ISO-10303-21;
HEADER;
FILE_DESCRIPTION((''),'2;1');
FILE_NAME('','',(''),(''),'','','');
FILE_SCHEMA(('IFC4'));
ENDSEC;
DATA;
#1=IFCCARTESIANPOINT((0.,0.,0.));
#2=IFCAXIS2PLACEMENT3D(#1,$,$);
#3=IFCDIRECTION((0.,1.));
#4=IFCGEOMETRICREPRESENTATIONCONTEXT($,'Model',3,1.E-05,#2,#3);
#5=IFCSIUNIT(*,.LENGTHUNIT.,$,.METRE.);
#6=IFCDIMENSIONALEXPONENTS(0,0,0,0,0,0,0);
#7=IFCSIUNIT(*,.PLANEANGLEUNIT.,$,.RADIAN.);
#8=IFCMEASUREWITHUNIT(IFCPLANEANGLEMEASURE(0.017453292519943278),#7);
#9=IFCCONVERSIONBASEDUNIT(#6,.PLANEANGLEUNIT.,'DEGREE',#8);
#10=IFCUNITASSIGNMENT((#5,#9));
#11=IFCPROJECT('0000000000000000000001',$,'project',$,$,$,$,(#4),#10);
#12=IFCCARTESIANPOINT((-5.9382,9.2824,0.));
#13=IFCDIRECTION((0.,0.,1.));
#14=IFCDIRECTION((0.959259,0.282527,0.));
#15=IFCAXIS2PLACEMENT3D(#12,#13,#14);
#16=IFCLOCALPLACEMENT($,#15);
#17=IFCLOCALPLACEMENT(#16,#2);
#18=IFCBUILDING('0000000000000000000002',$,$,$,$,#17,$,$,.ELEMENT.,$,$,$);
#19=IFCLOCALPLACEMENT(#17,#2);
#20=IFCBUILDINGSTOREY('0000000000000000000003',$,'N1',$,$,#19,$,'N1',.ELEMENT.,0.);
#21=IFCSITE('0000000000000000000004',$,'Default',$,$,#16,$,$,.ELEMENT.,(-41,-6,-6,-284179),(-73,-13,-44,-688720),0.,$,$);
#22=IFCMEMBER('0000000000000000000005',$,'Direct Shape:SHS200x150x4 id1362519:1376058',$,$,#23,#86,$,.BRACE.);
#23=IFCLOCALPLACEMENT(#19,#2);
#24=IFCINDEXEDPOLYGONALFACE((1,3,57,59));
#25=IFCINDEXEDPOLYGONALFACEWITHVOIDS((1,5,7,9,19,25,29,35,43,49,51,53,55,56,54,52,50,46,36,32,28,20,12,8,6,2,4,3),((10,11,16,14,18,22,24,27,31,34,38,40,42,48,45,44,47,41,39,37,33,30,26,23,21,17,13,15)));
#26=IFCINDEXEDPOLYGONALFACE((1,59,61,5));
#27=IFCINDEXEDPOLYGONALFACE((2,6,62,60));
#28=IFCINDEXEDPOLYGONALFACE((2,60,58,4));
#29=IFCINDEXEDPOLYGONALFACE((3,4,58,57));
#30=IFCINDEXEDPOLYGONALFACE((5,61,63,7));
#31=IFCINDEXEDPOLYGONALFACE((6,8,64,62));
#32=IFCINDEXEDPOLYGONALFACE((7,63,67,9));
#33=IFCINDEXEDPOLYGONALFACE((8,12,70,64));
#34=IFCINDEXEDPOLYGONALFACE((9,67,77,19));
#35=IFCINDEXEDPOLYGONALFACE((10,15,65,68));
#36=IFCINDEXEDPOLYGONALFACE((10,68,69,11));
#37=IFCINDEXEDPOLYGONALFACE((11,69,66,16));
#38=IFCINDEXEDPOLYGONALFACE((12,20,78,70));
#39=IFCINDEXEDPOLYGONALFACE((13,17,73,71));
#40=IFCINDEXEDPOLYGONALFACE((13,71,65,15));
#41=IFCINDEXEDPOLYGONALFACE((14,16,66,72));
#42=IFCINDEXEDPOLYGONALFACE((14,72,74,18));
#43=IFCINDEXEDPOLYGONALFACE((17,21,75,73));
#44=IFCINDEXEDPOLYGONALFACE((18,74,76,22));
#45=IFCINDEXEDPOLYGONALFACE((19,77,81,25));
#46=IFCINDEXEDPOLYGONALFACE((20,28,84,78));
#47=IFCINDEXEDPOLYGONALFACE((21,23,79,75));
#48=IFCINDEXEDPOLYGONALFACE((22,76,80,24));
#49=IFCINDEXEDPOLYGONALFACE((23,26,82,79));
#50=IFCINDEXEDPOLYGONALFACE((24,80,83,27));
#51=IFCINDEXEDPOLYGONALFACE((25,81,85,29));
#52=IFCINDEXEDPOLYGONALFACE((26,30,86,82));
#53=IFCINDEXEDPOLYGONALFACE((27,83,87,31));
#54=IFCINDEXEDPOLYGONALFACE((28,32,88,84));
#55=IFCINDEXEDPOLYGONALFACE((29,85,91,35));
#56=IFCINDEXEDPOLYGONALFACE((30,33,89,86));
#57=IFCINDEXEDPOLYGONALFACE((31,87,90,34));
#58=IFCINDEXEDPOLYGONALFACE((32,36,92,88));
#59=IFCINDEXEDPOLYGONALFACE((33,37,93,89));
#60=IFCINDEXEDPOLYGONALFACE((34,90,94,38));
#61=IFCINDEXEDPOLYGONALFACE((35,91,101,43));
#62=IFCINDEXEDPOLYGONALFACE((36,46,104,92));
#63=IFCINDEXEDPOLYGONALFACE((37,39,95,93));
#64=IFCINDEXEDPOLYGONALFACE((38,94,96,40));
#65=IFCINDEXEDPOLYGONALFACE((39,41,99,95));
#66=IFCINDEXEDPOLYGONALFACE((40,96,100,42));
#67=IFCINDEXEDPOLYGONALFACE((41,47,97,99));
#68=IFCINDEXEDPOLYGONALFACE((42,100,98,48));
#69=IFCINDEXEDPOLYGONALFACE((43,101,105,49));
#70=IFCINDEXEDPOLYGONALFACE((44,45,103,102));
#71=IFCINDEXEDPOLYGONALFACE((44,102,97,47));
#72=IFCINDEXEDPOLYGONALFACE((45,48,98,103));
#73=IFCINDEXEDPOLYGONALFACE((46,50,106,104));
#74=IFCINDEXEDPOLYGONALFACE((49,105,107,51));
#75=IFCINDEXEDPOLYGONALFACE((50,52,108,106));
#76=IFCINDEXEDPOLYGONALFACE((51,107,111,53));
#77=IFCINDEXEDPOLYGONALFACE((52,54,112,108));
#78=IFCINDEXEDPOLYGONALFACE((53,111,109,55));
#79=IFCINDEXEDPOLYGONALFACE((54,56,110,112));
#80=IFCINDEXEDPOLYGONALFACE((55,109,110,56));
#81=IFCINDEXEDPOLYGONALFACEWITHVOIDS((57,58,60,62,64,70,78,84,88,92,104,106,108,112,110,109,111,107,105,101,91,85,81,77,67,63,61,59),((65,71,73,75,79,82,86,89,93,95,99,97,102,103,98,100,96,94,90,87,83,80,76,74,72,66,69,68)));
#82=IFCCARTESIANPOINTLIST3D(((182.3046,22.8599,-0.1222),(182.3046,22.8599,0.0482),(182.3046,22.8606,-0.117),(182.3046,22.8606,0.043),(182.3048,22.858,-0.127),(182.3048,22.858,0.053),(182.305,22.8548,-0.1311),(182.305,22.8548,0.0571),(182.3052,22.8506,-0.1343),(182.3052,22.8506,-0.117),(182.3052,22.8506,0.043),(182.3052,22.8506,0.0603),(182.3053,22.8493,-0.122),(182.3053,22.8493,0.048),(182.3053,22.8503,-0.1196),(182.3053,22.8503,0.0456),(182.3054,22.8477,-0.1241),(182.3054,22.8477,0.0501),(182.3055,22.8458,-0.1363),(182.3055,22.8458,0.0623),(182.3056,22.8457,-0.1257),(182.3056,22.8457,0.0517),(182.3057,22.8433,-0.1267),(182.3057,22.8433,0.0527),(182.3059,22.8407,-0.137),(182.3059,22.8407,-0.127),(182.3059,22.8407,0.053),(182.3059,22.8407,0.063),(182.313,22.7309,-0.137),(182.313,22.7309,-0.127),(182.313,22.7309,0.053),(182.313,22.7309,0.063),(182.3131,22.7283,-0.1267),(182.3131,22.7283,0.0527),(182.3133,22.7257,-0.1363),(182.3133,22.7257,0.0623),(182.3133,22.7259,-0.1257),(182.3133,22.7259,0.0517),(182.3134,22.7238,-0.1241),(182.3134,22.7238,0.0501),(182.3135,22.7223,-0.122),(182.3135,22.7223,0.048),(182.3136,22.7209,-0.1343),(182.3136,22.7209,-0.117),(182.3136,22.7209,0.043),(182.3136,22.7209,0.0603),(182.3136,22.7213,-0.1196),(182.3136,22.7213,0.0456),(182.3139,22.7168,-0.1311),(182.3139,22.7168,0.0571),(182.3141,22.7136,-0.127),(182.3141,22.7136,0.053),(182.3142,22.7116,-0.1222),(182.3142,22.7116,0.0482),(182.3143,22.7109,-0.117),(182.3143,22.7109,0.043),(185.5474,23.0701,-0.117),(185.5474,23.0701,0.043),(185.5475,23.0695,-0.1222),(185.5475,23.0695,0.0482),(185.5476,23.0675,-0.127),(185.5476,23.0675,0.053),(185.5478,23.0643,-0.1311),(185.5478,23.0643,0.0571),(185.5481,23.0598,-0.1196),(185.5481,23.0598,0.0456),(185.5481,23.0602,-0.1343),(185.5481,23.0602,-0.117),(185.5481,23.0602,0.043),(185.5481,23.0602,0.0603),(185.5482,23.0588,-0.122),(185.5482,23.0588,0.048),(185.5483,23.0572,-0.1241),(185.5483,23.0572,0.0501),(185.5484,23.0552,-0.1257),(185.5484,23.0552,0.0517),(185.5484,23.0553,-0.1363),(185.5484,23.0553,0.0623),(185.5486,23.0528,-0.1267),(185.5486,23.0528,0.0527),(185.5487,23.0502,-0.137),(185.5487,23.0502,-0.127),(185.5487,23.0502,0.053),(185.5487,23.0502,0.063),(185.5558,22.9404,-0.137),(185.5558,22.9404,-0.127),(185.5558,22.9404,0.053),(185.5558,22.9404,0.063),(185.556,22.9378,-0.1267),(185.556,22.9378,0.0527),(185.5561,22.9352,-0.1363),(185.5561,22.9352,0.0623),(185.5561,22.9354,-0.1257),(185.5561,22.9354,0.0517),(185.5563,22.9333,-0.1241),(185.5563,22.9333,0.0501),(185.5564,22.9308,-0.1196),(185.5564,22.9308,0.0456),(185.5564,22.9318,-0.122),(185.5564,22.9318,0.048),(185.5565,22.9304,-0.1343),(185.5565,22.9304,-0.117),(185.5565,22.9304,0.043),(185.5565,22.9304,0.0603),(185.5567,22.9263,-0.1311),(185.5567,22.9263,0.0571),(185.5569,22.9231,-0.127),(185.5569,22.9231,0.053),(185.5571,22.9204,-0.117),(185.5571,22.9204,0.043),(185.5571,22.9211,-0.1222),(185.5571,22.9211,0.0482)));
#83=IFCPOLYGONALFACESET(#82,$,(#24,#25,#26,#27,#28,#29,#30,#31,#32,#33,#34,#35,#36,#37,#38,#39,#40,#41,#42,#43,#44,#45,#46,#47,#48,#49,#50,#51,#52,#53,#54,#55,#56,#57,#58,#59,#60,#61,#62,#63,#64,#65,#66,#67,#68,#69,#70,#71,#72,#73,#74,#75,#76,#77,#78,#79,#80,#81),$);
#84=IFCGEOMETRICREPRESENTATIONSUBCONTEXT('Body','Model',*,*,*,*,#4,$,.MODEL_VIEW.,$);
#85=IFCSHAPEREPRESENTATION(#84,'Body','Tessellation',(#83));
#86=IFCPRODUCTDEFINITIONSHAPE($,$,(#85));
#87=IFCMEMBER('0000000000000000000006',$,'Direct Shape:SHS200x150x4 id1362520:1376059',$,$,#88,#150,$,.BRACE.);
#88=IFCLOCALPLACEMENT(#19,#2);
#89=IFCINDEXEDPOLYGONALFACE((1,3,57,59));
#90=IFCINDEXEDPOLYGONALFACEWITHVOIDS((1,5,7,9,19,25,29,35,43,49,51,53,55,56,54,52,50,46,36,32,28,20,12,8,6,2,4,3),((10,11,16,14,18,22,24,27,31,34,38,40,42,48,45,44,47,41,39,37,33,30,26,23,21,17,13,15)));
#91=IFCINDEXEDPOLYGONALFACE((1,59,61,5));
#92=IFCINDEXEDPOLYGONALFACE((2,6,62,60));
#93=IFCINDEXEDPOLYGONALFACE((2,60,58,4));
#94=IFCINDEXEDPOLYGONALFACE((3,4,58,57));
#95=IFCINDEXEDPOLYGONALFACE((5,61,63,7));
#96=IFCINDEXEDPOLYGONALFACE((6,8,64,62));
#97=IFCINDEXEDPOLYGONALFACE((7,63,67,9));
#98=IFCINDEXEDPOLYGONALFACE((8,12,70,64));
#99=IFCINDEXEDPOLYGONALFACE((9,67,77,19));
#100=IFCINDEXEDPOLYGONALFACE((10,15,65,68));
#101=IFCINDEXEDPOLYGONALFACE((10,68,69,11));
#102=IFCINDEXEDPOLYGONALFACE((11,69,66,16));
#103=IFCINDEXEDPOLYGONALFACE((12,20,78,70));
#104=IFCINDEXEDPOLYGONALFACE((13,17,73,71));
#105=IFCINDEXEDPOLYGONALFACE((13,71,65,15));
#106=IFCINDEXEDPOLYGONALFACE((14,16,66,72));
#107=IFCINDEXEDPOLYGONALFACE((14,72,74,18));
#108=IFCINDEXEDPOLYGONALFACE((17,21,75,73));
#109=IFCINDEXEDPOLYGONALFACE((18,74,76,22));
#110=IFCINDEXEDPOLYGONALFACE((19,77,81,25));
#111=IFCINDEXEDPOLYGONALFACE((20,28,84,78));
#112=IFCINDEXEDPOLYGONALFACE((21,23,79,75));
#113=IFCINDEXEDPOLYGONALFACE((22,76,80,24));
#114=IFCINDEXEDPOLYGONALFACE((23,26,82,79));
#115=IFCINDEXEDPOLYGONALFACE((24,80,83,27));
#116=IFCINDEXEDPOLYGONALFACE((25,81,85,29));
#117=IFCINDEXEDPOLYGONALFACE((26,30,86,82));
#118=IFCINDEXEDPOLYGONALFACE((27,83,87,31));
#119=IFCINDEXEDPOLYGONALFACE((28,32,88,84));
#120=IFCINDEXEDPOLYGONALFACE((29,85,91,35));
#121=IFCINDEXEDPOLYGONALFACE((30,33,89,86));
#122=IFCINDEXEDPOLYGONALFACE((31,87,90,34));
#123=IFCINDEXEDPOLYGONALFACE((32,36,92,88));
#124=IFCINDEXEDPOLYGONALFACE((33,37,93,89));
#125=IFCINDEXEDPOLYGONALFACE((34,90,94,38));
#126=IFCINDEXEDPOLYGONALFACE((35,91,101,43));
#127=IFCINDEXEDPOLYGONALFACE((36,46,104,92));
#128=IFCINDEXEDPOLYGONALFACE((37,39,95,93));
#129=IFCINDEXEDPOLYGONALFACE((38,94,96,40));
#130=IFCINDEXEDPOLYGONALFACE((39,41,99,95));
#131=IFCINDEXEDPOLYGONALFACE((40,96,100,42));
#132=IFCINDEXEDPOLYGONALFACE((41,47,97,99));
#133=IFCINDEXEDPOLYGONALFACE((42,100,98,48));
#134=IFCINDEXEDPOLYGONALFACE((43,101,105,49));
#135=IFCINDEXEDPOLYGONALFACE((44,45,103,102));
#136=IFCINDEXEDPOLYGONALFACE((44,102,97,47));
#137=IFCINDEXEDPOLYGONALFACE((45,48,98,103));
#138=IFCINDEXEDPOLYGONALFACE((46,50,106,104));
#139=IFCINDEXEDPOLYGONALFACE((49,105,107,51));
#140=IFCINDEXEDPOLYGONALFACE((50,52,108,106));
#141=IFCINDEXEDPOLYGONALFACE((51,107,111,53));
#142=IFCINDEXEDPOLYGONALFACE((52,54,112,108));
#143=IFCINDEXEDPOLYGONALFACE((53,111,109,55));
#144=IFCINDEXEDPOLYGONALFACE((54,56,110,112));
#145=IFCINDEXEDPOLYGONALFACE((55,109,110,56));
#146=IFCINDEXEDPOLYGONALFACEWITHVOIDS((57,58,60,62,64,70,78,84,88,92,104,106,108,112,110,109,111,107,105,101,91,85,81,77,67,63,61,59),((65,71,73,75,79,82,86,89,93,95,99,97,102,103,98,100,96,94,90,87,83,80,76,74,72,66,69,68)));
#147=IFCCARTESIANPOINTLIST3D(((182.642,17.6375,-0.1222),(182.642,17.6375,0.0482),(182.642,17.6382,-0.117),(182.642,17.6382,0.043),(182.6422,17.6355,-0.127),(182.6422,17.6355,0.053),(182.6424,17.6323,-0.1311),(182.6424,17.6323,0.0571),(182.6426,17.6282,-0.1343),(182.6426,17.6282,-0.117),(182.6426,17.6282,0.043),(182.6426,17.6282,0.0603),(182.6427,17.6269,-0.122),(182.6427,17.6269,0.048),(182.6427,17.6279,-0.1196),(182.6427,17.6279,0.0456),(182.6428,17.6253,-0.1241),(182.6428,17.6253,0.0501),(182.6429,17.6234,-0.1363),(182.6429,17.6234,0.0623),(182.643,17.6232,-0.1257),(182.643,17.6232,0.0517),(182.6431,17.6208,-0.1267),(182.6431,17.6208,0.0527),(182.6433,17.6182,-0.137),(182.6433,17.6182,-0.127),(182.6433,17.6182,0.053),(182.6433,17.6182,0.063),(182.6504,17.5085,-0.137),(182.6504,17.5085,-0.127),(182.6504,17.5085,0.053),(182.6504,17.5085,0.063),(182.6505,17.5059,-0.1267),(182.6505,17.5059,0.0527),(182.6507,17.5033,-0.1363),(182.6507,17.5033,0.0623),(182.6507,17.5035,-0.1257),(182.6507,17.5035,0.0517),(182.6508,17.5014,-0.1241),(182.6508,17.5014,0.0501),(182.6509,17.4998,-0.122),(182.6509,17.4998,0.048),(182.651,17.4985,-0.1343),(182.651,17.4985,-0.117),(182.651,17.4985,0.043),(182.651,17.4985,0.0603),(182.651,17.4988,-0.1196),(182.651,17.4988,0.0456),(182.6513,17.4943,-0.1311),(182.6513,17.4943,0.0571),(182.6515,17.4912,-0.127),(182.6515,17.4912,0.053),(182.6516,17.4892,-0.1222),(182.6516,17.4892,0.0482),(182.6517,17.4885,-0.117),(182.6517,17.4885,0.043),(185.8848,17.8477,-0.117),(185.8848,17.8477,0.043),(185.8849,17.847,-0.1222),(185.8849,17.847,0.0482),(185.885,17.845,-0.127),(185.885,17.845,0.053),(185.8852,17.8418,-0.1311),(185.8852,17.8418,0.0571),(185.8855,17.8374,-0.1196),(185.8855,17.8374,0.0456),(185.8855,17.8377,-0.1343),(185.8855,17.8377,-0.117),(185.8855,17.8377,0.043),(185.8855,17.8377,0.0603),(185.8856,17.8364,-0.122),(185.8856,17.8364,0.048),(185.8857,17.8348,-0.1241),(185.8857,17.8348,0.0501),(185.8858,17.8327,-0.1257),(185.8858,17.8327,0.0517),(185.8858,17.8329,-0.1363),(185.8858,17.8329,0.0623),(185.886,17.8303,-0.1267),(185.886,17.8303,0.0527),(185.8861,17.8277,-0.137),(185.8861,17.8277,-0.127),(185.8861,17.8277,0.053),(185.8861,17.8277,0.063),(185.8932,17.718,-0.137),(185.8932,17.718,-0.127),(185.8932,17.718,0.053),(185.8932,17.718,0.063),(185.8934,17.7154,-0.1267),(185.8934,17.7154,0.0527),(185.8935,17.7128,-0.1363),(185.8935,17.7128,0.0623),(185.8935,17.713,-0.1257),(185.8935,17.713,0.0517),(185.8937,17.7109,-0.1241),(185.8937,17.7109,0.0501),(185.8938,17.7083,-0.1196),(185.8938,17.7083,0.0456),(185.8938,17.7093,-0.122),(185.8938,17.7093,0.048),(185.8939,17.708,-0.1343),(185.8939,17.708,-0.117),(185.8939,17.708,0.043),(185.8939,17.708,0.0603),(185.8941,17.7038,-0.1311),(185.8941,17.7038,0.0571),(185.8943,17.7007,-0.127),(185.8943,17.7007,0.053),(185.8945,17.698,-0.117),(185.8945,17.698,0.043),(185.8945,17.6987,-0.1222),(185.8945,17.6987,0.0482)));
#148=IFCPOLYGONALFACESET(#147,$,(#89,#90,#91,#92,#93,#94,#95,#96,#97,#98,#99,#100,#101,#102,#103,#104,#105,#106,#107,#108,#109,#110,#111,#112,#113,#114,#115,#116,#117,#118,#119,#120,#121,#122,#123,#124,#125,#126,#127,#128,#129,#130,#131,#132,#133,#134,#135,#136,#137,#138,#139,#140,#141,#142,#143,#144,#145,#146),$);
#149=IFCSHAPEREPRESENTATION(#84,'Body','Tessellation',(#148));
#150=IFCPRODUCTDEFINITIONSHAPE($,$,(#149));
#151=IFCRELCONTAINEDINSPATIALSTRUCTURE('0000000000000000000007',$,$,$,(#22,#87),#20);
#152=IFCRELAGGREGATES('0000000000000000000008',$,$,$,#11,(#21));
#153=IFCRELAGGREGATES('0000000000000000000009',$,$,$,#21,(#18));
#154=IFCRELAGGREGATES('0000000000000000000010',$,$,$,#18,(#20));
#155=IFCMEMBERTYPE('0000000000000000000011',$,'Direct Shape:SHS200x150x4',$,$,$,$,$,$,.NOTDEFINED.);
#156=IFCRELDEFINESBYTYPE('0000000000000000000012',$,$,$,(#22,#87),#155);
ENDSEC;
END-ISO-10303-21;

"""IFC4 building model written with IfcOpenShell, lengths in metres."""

from ifc_helpers import new_model, entity, si_unit, converted_unit, direction, frame, frame_2d, origin, place, context, subcontext, project, spatial, polyline, circle_curve, parameter, trimmed, segment, composite_curve, outline, extrude, type_object, element, save


model = new_model("IFC4")

# Units and contexts
model_context = context("Model", 3, precision=1e-05, world=origin(), true_north=direction((0.0, 1.0)))
body_context = subcontext(model_context, "Body", "Model", "MODEL_VIEW")
ifc_project = project(units=[si_unit("LENGTHUNIT", "METRE"), converted_unit("PLANEANGLEUNIT", "DEGREE", entity("IfcPlaneAngleMeasure", 0.017453292519943278), si_unit("PLANEANGLEUNIT", "RADIAN"), dimensions=[0, 0, 0, 0, 0, 0, 0])], contexts=[model_context])

# Site, building, storey
site_placement = place(None, frame((-5.9382, 9.2824, 0.0), z_axis=(0.0, 0.0, 1.0), x_axis=(0.959259, 0.282527, 0.0)))
site = spatial("IfcSite", under=ifc_project, at=site_placement, Name="Default", CompositionType="ELEMENT", RefLatitude=(-41, -6, -6, -284179), RefLongitude=(-73, -13, -44, -688720), RefElevation=0.0)
building_placement = place(site_placement, origin())
building = spatial("IfcBuilding", under=site, at=building_placement, CompositionType="ELEMENT")
storey_placement = place(building_placement, origin())
storey = spatial("IfcBuildingStorey", under=building, at=storey_placement, Name="N1", LongName="N1", CompositionType="ELEMENT", Elevation=0.0)

# Members
member_type_1 = type_object("IfcMemberType", Name="Direct Shape:SHS200x150x4", PredefinedType="NOTDEFINED")
member_1_placement = place(storey_placement, origin())
element("IfcMember", 1, at=member_1_placement, inside=storey, type_object=member_type_1, Name="Direct Shape:SHS200x150x4 id1362519:1376058", PredefinedType="BRACE", context=body_context, shape_type="SweptSolid", body=[
    extrude(outline(composite_curve([segment(polyline([(-0.08, -0.075), (0.08, -0.075)]), True, "CONTINUOUS"), segment(trimmed(circle_curve(frame_2d((0.08, -0.055), x_axis=(0.0, 1.0)), 0.02), [parameter(180.0)], [parameter(270.0)], True, "PARAMETER"), True, "CONTINUOUS"), segment(polyline([(0.1, -0.055), (0.1, 0.055)]), True, "CONTINUOUS"), segment(trimmed(circle_curve(frame_2d((0.08, 0.055), x_axis=(0.0, 1.0)), 0.02), [parameter(270.0)], [parameter(0.0)], True, "PARAMETER"), True, "CONTINUOUS"), segment(polyline([(0.08, 0.075), (-0.08, 0.075)]), True, "CONTINUOUS"), segment(trimmed(circle_curve(frame_2d((-0.08, 0.055), x_axis=(0.0, 1.0)), 0.02), [parameter(360.0)], [parameter(90.0)], True, "PARAMETER"), True, "CONTINUOUS"), segment(polyline([(-0.1, 0.055), (-0.1, -0.055)]), True, "CONTINUOUS"), segment(trimmed(circle_curve(frame_2d((-0.08, -0.055), x_axis=(0.0, 1.0)), 0.02), [parameter(90.0)], [parameter(180.0)], True, "PARAMETER"), True, "CONTINUOUS")], self_intersect=False), holes=[composite_curve([segment(trimmed(circle_curve(frame_2d((-0.08, 0.055), x_axis=(0.0, 1.0)), 0.01), [parameter(360.0)], [parameter(90.0)], True, "PARAMETER"), False, "CONTINUOUS"), segment(polyline([(-0.08, 0.065), (0.08, 0.065)]), True, "CONTINUOUS"), segment(trimmed(circle_curve(frame_2d((0.08, 0.055), x_axis=(0.0, 1.0)), 0.01), [parameter(270.0)], [parameter(0.0)], True, "PARAMETER"), False, "CONTINUOUS"), segment(polyline([(0.09, 0.055), (0.09, -0.055)]), True, "CONTINUOUS"), segment(trimmed(circle_curve(frame_2d((0.08, -0.055), x_axis=(0.0, 1.0)), 0.01), [parameter(180.0)], [parameter(270.0)], True, "PARAMETER"), False, "CONTINUOUS"), segment(polyline([(0.08, -0.065), (-0.08, -0.065)]), True, "CONTINUOUS"), segment(trimmed(circle_curve(frame_2d((-0.08, -0.055), x_axis=(0.0, 1.0)), 0.01), [parameter(90.0)], [parameter(180.0)], True, "PARAMETER"), False, "CONTINUOUS"), segment(polyline([(-0.09, -0.055), (-0.09, 0.055)]), True, "CONTINUOUS")], self_intersect=False)]), frame((182.3094, 22.7858, -0.037), z_axis=(0.99792, 0.064471, 0.0), x_axis=(0.0, 0.0, -1.0)), (0.0, 0.0, 1.0), 3.2496),
])
member_2_placement = place(storey_placement, origin())
element("IfcMember", 2, at=member_2_placement, inside=storey, type_object=member_type_1, Name="Direct Shape:SHS200x150x4 id1362520:1376059", PredefinedType="BRACE", context=body_context, shape_type="SweptSolid", body=[
    extrude(outline(composite_curve([segment(polyline([(-0.08, -0.075), (0.08, -0.075)]), True, "CONTINUOUS"), segment(trimmed(circle_curve(frame_2d((0.08, -0.055), x_axis=(0.0, 1.0)), 0.02), [parameter(180.0)], [parameter(270.0)], True, "PARAMETER"), True, "CONTINUOUS"), segment(polyline([(0.1, -0.055), (0.1, 0.055)]), True, "CONTINUOUS"), segment(trimmed(circle_curve(frame_2d((0.08, 0.055), x_axis=(0.0, 1.0)), 0.02), [parameter(270.0)], [parameter(0.0)], True, "PARAMETER"), True, "CONTINUOUS"), segment(polyline([(0.08, 0.075), (-0.08, 0.075)]), True, "CONTINUOUS"), segment(trimmed(circle_curve(frame_2d((-0.08, 0.055), x_axis=(0.0, 1.0)), 0.02), [parameter(360.0)], [parameter(90.0)], True, "PARAMETER"), True, "CONTINUOUS"), segment(polyline([(-0.1, 0.055), (-0.1, -0.055)]), True, "CONTINUOUS"), segment(trimmed(circle_curve(frame_2d((-0.08, -0.055), x_axis=(0.0, 1.0)), 0.02), [parameter(90.0)], [parameter(180.0)], True, "PARAMETER"), True, "CONTINUOUS")], self_intersect=False), holes=[composite_curve([segment(trimmed(circle_curve(frame_2d((-0.08, 0.055), x_axis=(0.0, 1.0)), 0.01), [parameter(360.0)], [parameter(90.0)], True, "PARAMETER"), False, "CONTINUOUS"), segment(polyline([(-0.08, 0.065), (0.08, 0.065)]), True, "CONTINUOUS"), segment(trimmed(circle_curve(frame_2d((0.08, 0.055), x_axis=(0.0, 1.0)), 0.01), [parameter(270.0)], [parameter(0.0)], True, "PARAMETER"), False, "CONTINUOUS"), segment(polyline([(0.09, 0.055), (0.09, -0.055)]), True, "CONTINUOUS"), segment(trimmed(circle_curve(frame_2d((0.08, -0.055), x_axis=(0.0, 1.0)), 0.01), [parameter(180.0)], [parameter(270.0)], True, "PARAMETER"), False, "CONTINUOUS"), segment(polyline([(0.08, -0.065), (-0.08, -0.065)]), True, "CONTINUOUS"), segment(trimmed(circle_curve(frame_2d((-0.08, -0.055), x_axis=(0.0, 1.0)), 0.01), [parameter(90.0)], [parameter(180.0)], True, "PARAMETER"), False, "CONTINUOUS"), segment(polyline([(-0.09, -0.055), (-0.09, 0.055)]), True, "CONTINUOUS")], self_intersect=False)]), frame((182.6468, 17.5633, -0.037), z_axis=(0.99792, 0.064471, 0.0), x_axis=(0.0, 0.0, -1.0)), (0.0, 0.0, 1.0), 3.2496),
])

save(model, "model.ifc")
